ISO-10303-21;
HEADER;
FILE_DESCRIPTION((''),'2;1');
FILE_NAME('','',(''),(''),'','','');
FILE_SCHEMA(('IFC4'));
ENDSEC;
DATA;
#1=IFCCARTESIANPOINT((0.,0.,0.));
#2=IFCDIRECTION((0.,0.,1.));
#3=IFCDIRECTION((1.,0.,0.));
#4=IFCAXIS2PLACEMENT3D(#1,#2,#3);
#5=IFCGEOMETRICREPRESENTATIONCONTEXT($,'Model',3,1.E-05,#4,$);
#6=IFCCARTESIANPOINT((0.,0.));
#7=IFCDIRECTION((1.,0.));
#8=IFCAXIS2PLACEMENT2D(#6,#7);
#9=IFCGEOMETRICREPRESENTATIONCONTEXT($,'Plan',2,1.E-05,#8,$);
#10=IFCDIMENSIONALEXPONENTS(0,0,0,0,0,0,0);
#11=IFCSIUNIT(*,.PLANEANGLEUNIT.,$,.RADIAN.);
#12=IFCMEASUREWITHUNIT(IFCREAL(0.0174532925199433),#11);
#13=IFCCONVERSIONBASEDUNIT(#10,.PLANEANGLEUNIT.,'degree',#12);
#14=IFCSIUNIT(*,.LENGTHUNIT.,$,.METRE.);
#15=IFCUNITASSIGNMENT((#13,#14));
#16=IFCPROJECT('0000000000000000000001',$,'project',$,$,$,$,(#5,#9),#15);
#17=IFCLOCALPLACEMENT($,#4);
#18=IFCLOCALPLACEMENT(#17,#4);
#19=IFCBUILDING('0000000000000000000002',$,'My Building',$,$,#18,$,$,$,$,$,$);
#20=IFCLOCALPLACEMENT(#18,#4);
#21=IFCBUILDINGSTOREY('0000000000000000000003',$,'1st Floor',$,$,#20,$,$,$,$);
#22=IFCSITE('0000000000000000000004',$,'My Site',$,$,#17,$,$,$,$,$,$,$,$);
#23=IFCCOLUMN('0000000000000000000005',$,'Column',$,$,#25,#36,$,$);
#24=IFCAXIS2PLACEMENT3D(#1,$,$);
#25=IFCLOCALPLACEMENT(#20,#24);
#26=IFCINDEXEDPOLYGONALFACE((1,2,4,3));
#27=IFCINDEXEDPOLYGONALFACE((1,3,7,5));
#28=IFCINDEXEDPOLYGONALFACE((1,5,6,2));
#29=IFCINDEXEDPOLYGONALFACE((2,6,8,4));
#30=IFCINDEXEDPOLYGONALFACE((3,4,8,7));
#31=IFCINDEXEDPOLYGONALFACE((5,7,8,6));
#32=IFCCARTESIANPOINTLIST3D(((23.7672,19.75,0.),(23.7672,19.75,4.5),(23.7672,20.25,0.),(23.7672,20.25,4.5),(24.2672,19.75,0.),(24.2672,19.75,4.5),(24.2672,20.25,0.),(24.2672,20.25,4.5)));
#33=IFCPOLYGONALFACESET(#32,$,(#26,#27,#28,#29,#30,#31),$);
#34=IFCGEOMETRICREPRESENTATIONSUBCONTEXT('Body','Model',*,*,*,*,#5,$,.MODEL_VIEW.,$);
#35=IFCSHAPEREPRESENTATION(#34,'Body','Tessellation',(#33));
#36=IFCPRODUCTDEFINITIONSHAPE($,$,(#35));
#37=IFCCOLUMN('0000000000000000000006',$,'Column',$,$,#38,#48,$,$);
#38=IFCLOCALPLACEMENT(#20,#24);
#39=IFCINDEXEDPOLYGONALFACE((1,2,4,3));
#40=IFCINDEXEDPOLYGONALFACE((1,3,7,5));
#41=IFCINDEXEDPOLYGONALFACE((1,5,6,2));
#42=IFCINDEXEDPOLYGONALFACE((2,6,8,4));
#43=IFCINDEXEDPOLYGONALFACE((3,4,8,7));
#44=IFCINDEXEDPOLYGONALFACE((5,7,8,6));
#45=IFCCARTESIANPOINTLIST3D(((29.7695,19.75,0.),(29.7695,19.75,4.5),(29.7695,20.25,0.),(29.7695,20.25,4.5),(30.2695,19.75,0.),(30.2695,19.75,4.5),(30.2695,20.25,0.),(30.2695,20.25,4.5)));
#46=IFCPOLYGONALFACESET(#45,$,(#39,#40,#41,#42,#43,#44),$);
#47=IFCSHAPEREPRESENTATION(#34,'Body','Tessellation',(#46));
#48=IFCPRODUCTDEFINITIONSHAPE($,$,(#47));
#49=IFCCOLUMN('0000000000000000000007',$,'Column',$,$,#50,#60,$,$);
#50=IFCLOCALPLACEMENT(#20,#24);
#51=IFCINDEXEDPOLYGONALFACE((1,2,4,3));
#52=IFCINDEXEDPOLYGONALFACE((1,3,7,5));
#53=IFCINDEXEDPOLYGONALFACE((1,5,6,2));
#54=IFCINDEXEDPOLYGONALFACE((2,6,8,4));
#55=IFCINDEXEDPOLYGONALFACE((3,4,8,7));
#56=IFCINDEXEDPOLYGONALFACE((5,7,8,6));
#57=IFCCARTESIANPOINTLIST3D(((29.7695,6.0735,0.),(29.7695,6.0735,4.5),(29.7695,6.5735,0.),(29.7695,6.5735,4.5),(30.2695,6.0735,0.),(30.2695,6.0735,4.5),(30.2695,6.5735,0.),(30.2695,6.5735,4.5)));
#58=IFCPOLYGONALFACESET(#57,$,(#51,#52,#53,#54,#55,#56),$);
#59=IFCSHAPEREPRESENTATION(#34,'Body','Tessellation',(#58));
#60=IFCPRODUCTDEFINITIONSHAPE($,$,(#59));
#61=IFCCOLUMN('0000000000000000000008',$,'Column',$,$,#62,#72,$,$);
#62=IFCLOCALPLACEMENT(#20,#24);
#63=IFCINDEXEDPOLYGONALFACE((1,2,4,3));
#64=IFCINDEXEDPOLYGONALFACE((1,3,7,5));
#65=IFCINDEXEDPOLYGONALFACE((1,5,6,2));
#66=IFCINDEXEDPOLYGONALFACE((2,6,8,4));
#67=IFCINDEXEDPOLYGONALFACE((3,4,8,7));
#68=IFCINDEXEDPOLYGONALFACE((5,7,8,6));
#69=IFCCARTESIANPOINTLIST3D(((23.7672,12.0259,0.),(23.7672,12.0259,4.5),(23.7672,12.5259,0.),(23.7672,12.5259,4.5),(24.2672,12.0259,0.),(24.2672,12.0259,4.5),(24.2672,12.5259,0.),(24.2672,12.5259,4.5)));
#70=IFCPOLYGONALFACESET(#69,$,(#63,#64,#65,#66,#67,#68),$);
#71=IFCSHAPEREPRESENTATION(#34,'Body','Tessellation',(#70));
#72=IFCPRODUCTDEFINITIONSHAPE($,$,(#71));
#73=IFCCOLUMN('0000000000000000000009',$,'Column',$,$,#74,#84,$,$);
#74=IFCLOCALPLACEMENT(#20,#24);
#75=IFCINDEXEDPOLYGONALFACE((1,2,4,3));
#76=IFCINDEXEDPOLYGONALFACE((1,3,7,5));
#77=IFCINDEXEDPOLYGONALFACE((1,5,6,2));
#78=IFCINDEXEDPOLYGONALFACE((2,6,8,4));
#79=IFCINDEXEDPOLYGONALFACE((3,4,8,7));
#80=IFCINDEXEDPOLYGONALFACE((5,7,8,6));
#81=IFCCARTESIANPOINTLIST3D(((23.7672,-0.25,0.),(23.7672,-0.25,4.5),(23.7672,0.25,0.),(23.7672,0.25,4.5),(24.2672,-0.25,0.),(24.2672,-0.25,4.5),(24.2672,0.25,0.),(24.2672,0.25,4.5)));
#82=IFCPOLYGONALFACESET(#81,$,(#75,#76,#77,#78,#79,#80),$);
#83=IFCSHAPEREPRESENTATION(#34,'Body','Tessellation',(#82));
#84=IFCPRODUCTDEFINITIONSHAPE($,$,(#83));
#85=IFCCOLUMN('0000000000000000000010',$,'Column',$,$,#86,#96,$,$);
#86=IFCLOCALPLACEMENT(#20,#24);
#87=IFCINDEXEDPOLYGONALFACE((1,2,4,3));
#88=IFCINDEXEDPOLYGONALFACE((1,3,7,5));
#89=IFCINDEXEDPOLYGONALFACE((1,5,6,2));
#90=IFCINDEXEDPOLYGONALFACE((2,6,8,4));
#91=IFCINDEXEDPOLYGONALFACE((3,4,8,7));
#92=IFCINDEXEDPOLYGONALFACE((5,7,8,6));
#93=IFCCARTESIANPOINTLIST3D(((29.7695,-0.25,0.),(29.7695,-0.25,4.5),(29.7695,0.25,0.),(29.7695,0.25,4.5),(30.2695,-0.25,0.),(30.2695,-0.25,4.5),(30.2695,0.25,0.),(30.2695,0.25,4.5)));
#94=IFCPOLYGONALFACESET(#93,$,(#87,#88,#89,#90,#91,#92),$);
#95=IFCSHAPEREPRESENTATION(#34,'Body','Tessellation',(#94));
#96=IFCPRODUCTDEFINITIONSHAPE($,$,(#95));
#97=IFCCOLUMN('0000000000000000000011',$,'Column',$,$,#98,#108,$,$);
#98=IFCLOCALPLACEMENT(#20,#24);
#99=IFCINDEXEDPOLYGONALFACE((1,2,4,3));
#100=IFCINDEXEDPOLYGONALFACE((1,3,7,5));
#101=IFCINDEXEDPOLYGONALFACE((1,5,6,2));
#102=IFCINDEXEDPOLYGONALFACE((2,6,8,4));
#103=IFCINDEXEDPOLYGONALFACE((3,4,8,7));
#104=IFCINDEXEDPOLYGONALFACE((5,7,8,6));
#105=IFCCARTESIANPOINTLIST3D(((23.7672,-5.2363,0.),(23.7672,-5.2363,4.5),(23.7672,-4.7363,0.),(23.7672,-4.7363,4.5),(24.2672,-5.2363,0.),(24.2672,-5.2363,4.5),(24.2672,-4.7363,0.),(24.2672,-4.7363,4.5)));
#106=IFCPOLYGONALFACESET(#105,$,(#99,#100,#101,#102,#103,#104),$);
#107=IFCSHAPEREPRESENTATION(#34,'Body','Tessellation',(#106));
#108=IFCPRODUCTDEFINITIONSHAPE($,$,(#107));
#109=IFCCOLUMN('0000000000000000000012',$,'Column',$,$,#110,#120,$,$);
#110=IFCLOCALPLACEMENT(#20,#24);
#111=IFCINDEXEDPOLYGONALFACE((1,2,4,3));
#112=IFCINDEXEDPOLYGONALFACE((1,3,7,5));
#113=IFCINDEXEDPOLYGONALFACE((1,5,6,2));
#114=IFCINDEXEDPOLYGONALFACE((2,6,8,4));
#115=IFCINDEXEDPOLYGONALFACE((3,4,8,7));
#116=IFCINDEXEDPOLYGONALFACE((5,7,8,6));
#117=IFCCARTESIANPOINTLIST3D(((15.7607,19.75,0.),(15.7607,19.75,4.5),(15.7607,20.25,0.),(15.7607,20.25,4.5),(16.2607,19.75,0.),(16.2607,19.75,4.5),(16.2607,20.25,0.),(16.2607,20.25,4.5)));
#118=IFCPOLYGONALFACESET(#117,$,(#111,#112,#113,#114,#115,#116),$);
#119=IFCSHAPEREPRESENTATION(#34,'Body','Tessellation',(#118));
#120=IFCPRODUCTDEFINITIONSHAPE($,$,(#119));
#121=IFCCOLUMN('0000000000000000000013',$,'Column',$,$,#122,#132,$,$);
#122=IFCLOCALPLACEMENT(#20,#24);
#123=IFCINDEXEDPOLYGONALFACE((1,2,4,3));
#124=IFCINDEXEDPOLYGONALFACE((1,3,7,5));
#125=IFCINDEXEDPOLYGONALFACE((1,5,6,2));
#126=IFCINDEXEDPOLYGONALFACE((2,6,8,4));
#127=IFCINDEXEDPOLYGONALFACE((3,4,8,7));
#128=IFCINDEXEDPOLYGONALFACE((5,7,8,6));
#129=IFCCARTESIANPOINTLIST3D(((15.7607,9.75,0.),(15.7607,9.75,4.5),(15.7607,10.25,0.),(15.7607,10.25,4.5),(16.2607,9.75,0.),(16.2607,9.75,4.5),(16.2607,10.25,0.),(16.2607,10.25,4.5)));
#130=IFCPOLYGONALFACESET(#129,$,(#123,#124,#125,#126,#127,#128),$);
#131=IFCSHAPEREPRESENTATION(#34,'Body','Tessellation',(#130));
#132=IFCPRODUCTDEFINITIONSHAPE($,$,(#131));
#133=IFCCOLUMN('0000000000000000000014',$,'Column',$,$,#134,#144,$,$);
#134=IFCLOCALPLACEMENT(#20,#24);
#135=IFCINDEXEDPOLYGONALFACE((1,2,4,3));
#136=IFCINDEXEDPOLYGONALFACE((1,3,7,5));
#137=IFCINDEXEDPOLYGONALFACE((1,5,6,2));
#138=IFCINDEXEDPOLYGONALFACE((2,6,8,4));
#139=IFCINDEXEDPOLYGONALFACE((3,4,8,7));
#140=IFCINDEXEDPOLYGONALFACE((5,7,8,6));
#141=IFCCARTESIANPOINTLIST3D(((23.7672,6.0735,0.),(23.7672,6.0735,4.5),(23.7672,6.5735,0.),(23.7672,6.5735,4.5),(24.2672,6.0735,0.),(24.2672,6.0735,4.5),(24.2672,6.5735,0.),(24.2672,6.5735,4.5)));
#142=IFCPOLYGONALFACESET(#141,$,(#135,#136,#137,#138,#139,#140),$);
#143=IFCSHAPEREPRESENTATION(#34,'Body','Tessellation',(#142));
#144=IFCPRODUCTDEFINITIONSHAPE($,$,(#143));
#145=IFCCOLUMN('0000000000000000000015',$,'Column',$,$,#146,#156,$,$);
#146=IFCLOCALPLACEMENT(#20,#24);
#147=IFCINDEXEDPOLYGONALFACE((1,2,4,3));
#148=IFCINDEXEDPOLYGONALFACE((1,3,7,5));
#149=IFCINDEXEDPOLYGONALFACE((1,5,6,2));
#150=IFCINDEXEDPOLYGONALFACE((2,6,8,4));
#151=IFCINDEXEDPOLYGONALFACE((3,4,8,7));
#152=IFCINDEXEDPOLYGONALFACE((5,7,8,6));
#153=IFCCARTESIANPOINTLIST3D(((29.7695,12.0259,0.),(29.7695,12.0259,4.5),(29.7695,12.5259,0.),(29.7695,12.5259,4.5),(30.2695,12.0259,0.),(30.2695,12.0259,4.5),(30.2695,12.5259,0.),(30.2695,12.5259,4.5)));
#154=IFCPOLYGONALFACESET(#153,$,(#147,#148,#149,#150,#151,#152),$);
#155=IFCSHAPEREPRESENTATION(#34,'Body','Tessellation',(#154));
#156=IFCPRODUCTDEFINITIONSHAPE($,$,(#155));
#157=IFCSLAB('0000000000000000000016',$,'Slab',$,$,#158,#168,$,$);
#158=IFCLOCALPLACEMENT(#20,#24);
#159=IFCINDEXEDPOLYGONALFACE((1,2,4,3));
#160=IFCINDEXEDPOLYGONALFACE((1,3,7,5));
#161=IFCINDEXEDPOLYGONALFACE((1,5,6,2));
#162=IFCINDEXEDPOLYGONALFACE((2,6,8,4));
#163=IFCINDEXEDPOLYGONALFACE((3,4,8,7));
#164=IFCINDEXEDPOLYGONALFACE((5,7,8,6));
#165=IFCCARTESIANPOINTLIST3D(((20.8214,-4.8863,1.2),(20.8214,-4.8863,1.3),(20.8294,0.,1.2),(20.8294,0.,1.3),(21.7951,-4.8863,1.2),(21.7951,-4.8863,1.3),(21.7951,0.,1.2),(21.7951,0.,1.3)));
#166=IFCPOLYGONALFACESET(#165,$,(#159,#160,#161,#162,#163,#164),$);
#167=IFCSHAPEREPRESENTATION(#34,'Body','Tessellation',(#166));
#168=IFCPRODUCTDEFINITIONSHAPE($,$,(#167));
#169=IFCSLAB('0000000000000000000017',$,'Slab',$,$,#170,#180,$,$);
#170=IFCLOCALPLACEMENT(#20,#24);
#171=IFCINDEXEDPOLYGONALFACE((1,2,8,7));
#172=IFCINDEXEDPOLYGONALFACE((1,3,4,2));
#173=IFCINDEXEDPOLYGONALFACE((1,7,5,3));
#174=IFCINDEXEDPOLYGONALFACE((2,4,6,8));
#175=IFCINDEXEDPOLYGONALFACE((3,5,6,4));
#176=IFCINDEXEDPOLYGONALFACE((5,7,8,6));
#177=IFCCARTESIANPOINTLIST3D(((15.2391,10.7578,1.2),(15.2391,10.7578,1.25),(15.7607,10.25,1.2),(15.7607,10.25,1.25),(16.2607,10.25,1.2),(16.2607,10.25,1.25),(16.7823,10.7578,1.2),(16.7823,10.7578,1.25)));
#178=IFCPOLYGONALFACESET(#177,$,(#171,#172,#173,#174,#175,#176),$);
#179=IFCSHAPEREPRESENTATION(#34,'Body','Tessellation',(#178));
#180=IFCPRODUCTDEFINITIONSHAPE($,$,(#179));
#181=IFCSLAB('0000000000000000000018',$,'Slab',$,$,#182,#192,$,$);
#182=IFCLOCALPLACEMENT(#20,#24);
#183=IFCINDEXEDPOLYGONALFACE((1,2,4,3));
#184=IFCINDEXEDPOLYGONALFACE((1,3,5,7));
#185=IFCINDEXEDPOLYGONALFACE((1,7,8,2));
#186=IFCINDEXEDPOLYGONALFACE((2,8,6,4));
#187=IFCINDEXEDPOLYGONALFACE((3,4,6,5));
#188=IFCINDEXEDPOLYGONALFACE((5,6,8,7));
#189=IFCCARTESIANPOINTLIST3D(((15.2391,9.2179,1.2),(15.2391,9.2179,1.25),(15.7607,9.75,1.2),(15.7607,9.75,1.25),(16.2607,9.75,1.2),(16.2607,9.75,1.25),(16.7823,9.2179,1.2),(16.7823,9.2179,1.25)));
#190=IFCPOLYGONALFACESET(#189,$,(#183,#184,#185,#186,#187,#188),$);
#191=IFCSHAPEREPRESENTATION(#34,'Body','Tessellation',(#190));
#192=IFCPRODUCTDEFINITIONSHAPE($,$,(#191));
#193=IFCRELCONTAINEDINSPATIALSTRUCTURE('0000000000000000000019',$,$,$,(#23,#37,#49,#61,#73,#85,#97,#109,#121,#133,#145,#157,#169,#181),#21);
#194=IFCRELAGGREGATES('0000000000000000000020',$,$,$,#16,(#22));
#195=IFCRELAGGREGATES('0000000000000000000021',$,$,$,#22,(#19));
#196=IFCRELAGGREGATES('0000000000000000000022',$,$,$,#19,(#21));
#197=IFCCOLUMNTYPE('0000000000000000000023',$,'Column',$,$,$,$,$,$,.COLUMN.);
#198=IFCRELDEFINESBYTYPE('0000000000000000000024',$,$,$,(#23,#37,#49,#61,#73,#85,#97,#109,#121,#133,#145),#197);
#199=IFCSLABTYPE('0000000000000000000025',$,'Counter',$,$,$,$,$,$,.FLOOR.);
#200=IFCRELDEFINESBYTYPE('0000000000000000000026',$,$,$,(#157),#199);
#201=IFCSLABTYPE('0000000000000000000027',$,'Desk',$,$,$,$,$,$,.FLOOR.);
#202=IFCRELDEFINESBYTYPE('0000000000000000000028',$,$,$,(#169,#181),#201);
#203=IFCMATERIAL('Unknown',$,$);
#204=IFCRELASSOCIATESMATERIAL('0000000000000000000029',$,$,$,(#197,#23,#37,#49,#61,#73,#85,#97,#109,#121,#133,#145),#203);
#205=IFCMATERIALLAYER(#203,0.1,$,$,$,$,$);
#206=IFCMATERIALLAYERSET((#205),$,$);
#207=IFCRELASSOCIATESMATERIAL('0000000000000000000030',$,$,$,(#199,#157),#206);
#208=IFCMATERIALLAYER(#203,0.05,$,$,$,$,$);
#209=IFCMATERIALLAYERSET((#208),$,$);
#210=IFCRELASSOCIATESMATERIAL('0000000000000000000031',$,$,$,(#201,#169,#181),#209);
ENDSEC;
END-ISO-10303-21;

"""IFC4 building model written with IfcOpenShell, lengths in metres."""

from ifc_helpers import new_model, entity, si_unit, converted_unit, frame, origin_with_axes, origin_2d_with_axis, place, context, subcontext, project, spatial, indexed_curve, rectangle, outline, extrude, material, layer, layer_set, layer_usage, material_profile, profile_set, profile_usage, type_object, element, save


model = new_model("IFC4")

# Units and contexts
model_context = context("Model", 3, precision=1e-05, world=origin_with_axes())
plan_context = context("Plan", 2, precision=1e-05, world=origin_2d_with_axis())
body_context_1 = subcontext(model_context, "Body", "Model", "MODEL_VIEW")
ifc_project = project(units=[converted_unit("PLANEANGLEUNIT", "degree", entity("IfcReal", 0.0174532925199433), si_unit("PLANEANGLEUNIT", "RADIAN"), dimensions=[0, 0, 0, 0, 0, 0, 0]), si_unit("LENGTHUNIT", "METRE")], contexts=[model_context, plan_context])

# Site, building, storey
site_placement = place(None, origin_with_axes())
site = spatial("IfcSite", under=ifc_project, at=site_placement, Name="My Site")
building_placement = place(site_placement, origin_with_axes())
building = spatial("IfcBuilding", under=site, at=building_placement, Name="My Building")
storey_placement = place(building_placement, origin_with_axes())
storey = spatial("IfcBuildingStorey", under=building, at=storey_placement, Name="1st Floor")

# Columns
ifc_material = material(Name="Unknown")
ifc_material_profile = material_profile(ifc_material, rectangle(XDim=0.5, YDim=0.5))
ifc_profile_set = profile_set([ifc_material_profile])
ifc_profile_usage_1 = profile_usage(ifc_profile_set, cardinal=5)
column_type = type_object("IfcColumnType", Name="Column", PredefinedType="COLUMN", material=ifc_profile_set)
column_1_placement = place(storey_placement, frame((24.0172, 20.0, 0.0), z_axis=(0.0, 0.0, 1.0), x_axis=(1.0, 0.0, 0.0)))
element("IfcColumn", 1, at=column_1_placement, inside=storey, type_object=column_type, material=ifc_profile_usage_1, Name="Column", context=body_context_1, shape_type="SweptSolid", body=[
    extrude(rectangle(XDim=0.5, YDim=0.5), origin_with_axes(), (0.0, 0.0, 1.0), 4.5),
])
ifc_profile_usage_2 = profile_usage(ifc_profile_set, cardinal=5)
column_2_placement = place(storey_placement, frame((30.0195, 20.0, 0.0), z_axis=(0.0, 0.0, 1.0), x_axis=(1.0, 0.0, 0.0)))
element("IfcColumn", 2, at=column_2_placement, inside=storey, type_object=column_type, material=ifc_profile_usage_2, Name="Column", context=body_context_1, shape_type="SweptSolid", body=[
    extrude(rectangle(XDim=0.5, YDim=0.5), origin_with_axes(), (0.0, 0.0, 1.0), 4.5),
])
ifc_profile_usage_3 = profile_usage(ifc_profile_set, cardinal=5)
column_3_placement = place(storey_placement, frame((30.0195, 6.3235, 0.0), z_axis=(0.0, 0.0, 1.0), x_axis=(1.0, 0.0, 0.0)))
element("IfcColumn", 3, at=column_3_placement, inside=storey, type_object=column_type, material=ifc_profile_usage_3, Name="Column", context=body_context_1, shape_type="SweptSolid", body=[
    extrude(rectangle(XDim=0.5, YDim=0.5), origin_with_axes(), (0.0, 0.0, 1.0), 4.5),
])
ifc_profile_usage_4 = profile_usage(ifc_profile_set, cardinal=5)
column_4_placement = place(storey_placement, frame((24.0172, 12.2759, 0.0), z_axis=(0.0, 0.0, 1.0), x_axis=(1.0, 0.0, 0.0)))
element("IfcColumn", 4, at=column_4_placement, inside=storey, type_object=column_type, material=ifc_profile_usage_4, Name="Column", context=body_context_1, shape_type="SweptSolid", body=[
    extrude(rectangle(XDim=0.5, YDim=0.5), origin_with_axes(), (0.0, 0.0, 1.0), 4.5),
])
ifc_profile_usage_5 = profile_usage(ifc_profile_set, cardinal=5)
column_5_placement = place(storey_placement, frame((24.0172, 0.0, 0.0), z_axis=(0.0, 0.0, 1.0), x_axis=(1.0, 0.0, 0.0)))
element("IfcColumn", 5, at=column_5_placement, inside=storey, type_object=column_type, material=ifc_profile_usage_5, Name="Column", context=body_context_1, shape_type="SweptSolid", body=[
    extrude(rectangle(XDim=0.5, YDim=0.5), origin_with_axes(), (0.0, 0.0, 1.0), 4.5),
])
ifc_profile_usage_6 = profile_usage(ifc_profile_set, cardinal=5)
column_6_placement = place(storey_placement, frame((30.0195, 0.0, 0.0), z_axis=(0.0, 0.0, 1.0), x_axis=(1.0, 0.0, 0.0)))
element("IfcColumn", 6, at=column_6_placement, inside=storey, type_object=column_type, material=ifc_profile_usage_6, Name="Column", context=body_context_1, shape_type="SweptSolid", body=[
    extrude(rectangle(XDim=0.5, YDim=0.5), origin_with_axes(), (0.0, 0.0, 1.0), 4.5),
])
ifc_profile_usage_7 = profile_usage(ifc_profile_set, cardinal=5)
column_7_placement = place(storey_placement, frame((24.0172, -4.9863, 0.0), z_axis=(0.0, 0.0, 1.0), x_axis=(1.0, 0.0, 0.0)))
element("IfcColumn", 7, at=column_7_placement, inside=storey, type_object=column_type, material=ifc_profile_usage_7, Name="Column", context=body_context_1, shape_type="SweptSolid", body=[
    extrude(rectangle(XDim=0.5, YDim=0.5), origin_with_axes(), (0.0, 0.0, 1.0), 4.5),
])
ifc_profile_usage_8 = profile_usage(ifc_profile_set, cardinal=5)
column_8_placement = place(storey_placement, frame((16.0107, 20.0, 0.0), z_axis=(0.0, 0.0, 1.0), x_axis=(1.0, 0.0, 0.0)))
element("IfcColumn", 8, at=column_8_placement, inside=storey, type_object=column_type, material=ifc_profile_usage_8, Name="Column", context=body_context_1, shape_type="SweptSolid", body=[
    extrude(rectangle(XDim=0.5, YDim=0.5), origin_with_axes(), (0.0, 0.0, 1.0), 4.5),
])
ifc_profile_usage_9 = profile_usage(ifc_profile_set, cardinal=5)
column_9_placement = place(storey_placement, frame((16.0107, 10.0, 0.0), z_axis=(0.0, 0.0, 1.0), x_axis=(1.0, 0.0, 0.0)))
element("IfcColumn", 9, at=column_9_placement, inside=storey, type_object=column_type, material=ifc_profile_usage_9, Name="Column", context=body_context_1, shape_type="SweptSolid", body=[
    extrude(rectangle(XDim=0.5, YDim=0.5), origin_with_axes(), (0.0, 0.0, 1.0), 4.5),
])
ifc_profile_usage_10 = profile_usage(ifc_profile_set, cardinal=5)
column_10_placement = place(storey_placement, frame((24.0172, 6.3235, 0.0), z_axis=(0.0, 0.0, 1.0), x_axis=(1.0, 0.0, 0.0)))
element("IfcColumn", 10, at=column_10_placement, inside=storey, type_object=column_type, material=ifc_profile_usage_10, Name="Column", context=body_context_1, shape_type="SweptSolid", body=[
    extrude(rectangle(XDim=0.5, YDim=0.5), origin_with_axes(), (0.0, 0.0, 1.0), 4.5),
])
ifc_profile_usage_11 = profile_usage(ifc_profile_set, cardinal=5)
column_11_placement = place(storey_placement, frame((30.0195, 12.2759, 0.0), z_axis=(0.0, 0.0, 1.0), x_axis=(1.0, 0.0, 0.0)))
element("IfcColumn", 11, at=column_11_placement, inside=storey, type_object=column_type, material=ifc_profile_usage_11, Name="Column", context=body_context_1, shape_type="SweptSolid", body=[
    extrude(rectangle(XDim=0.5, YDim=0.5), origin_with_axes(), (0.0, 0.0, 1.0), 4.5),
])

# Slabs
ifc_layer_1 = layer(ifc_material, 0.1)
ifc_layer_set_1 = layer_set([ifc_layer_1])
ifc_layer_usage_1 = layer_usage(ifc_layer_set_1, "AXIS3", "POSITIVE", -0.1)
slab_type_1 = type_object("IfcSlabType", Name="Counter", PredefinedType="FLOOR", material=ifc_layer_set_1)
slab_1_placement = place(storey_placement, frame((20.8294, 0.0, 1.3), z_axis=(0.0, 0.0, 1.0), x_axis=(1.0, 0.0, 0.0)))
element("IfcSlab", 12, at=slab_1_placement, inside=storey, type_object=slab_type_1, material=ifc_layer_usage_1, Name="Slab", context=body_context_1, shape_type="SweptSolid", body=[
    extrude(outline(indexed_curve([(0.0, 0.0), (-0.008, -4.8863), (0.9656, -4.8863), (0.9656, 0.0), (0.0, 0.0)])), frame((0.0, 0.0, -0.1), z_axis=(0.0, 0.0, 1.0), x_axis=(1.0, 0.0, 0.0)), (0.0, 0.0, 1.0), 0.1),
])
ifc_layer_2 = layer(ifc_material, 0.05)
ifc_layer_set_2 = layer_set([ifc_layer_2])
ifc_layer_usage_2 = layer_usage(ifc_layer_set_2, "AXIS3", "POSITIVE", -0.05)
slab_type_2 = type_object("IfcSlabType", Name="Desk", PredefinedType="FLOOR", material=ifc_layer_set_2)
slab_2_placement = place(storey_placement, frame((15.2391, 10.7578, 1.25), z_axis=(0.0, 0.0, 1.0), x_axis=(1.0, 0.0, 0.0)))
element("IfcSlab", 13, at=slab_2_placement, inside=storey, type_object=slab_type_2, material=ifc_layer_usage_2, Name="Slab", context=body_context_1, shape_type="SweptSolid", body=[
    extrude(outline(indexed_curve([(0.0, 0.0), (1.5432, 0.0), (1.0216, -0.5078), (0.5216, -0.5078), (0.0, 0.0)])), frame((0.0, 0.0, -0.05), z_axis=(0.0, 0.0, 1.0), x_axis=(1.0, 0.0, 0.0)), (0.0, 0.0, 1.0), 0.05),
])
ifc_layer_usage_3 = layer_usage(ifc_layer_set_2, "AXIS3", "POSITIVE", -0.05)
slab_3_placement = place(storey_placement, frame((16.7823, 9.2179, 1.25), z_axis=(0.0, 0.0, 1.0), x_axis=(1.0, 0.0, 0.0)))
element("IfcSlab", 14, at=slab_3_placement, inside=storey, type_object=slab_type_2, material=ifc_layer_usage_3, Name="Slab", context=body_context_1, shape_type="SweptSolid", body=[
    extrude(outline(indexed_curve([(0.0, 0.0), (-0.5216, 0.5321), (-1.0216, 0.5321), (-1.5432, 0.0), (0.0, 0.0)])), frame((0.0, 0.0, -0.05), z_axis=(0.0, 0.0, 1.0), x_axis=(1.0, 0.0, 0.0)), (0.0, 0.0, 1.0), 0.05),
])

save(model, "model.ifc")
